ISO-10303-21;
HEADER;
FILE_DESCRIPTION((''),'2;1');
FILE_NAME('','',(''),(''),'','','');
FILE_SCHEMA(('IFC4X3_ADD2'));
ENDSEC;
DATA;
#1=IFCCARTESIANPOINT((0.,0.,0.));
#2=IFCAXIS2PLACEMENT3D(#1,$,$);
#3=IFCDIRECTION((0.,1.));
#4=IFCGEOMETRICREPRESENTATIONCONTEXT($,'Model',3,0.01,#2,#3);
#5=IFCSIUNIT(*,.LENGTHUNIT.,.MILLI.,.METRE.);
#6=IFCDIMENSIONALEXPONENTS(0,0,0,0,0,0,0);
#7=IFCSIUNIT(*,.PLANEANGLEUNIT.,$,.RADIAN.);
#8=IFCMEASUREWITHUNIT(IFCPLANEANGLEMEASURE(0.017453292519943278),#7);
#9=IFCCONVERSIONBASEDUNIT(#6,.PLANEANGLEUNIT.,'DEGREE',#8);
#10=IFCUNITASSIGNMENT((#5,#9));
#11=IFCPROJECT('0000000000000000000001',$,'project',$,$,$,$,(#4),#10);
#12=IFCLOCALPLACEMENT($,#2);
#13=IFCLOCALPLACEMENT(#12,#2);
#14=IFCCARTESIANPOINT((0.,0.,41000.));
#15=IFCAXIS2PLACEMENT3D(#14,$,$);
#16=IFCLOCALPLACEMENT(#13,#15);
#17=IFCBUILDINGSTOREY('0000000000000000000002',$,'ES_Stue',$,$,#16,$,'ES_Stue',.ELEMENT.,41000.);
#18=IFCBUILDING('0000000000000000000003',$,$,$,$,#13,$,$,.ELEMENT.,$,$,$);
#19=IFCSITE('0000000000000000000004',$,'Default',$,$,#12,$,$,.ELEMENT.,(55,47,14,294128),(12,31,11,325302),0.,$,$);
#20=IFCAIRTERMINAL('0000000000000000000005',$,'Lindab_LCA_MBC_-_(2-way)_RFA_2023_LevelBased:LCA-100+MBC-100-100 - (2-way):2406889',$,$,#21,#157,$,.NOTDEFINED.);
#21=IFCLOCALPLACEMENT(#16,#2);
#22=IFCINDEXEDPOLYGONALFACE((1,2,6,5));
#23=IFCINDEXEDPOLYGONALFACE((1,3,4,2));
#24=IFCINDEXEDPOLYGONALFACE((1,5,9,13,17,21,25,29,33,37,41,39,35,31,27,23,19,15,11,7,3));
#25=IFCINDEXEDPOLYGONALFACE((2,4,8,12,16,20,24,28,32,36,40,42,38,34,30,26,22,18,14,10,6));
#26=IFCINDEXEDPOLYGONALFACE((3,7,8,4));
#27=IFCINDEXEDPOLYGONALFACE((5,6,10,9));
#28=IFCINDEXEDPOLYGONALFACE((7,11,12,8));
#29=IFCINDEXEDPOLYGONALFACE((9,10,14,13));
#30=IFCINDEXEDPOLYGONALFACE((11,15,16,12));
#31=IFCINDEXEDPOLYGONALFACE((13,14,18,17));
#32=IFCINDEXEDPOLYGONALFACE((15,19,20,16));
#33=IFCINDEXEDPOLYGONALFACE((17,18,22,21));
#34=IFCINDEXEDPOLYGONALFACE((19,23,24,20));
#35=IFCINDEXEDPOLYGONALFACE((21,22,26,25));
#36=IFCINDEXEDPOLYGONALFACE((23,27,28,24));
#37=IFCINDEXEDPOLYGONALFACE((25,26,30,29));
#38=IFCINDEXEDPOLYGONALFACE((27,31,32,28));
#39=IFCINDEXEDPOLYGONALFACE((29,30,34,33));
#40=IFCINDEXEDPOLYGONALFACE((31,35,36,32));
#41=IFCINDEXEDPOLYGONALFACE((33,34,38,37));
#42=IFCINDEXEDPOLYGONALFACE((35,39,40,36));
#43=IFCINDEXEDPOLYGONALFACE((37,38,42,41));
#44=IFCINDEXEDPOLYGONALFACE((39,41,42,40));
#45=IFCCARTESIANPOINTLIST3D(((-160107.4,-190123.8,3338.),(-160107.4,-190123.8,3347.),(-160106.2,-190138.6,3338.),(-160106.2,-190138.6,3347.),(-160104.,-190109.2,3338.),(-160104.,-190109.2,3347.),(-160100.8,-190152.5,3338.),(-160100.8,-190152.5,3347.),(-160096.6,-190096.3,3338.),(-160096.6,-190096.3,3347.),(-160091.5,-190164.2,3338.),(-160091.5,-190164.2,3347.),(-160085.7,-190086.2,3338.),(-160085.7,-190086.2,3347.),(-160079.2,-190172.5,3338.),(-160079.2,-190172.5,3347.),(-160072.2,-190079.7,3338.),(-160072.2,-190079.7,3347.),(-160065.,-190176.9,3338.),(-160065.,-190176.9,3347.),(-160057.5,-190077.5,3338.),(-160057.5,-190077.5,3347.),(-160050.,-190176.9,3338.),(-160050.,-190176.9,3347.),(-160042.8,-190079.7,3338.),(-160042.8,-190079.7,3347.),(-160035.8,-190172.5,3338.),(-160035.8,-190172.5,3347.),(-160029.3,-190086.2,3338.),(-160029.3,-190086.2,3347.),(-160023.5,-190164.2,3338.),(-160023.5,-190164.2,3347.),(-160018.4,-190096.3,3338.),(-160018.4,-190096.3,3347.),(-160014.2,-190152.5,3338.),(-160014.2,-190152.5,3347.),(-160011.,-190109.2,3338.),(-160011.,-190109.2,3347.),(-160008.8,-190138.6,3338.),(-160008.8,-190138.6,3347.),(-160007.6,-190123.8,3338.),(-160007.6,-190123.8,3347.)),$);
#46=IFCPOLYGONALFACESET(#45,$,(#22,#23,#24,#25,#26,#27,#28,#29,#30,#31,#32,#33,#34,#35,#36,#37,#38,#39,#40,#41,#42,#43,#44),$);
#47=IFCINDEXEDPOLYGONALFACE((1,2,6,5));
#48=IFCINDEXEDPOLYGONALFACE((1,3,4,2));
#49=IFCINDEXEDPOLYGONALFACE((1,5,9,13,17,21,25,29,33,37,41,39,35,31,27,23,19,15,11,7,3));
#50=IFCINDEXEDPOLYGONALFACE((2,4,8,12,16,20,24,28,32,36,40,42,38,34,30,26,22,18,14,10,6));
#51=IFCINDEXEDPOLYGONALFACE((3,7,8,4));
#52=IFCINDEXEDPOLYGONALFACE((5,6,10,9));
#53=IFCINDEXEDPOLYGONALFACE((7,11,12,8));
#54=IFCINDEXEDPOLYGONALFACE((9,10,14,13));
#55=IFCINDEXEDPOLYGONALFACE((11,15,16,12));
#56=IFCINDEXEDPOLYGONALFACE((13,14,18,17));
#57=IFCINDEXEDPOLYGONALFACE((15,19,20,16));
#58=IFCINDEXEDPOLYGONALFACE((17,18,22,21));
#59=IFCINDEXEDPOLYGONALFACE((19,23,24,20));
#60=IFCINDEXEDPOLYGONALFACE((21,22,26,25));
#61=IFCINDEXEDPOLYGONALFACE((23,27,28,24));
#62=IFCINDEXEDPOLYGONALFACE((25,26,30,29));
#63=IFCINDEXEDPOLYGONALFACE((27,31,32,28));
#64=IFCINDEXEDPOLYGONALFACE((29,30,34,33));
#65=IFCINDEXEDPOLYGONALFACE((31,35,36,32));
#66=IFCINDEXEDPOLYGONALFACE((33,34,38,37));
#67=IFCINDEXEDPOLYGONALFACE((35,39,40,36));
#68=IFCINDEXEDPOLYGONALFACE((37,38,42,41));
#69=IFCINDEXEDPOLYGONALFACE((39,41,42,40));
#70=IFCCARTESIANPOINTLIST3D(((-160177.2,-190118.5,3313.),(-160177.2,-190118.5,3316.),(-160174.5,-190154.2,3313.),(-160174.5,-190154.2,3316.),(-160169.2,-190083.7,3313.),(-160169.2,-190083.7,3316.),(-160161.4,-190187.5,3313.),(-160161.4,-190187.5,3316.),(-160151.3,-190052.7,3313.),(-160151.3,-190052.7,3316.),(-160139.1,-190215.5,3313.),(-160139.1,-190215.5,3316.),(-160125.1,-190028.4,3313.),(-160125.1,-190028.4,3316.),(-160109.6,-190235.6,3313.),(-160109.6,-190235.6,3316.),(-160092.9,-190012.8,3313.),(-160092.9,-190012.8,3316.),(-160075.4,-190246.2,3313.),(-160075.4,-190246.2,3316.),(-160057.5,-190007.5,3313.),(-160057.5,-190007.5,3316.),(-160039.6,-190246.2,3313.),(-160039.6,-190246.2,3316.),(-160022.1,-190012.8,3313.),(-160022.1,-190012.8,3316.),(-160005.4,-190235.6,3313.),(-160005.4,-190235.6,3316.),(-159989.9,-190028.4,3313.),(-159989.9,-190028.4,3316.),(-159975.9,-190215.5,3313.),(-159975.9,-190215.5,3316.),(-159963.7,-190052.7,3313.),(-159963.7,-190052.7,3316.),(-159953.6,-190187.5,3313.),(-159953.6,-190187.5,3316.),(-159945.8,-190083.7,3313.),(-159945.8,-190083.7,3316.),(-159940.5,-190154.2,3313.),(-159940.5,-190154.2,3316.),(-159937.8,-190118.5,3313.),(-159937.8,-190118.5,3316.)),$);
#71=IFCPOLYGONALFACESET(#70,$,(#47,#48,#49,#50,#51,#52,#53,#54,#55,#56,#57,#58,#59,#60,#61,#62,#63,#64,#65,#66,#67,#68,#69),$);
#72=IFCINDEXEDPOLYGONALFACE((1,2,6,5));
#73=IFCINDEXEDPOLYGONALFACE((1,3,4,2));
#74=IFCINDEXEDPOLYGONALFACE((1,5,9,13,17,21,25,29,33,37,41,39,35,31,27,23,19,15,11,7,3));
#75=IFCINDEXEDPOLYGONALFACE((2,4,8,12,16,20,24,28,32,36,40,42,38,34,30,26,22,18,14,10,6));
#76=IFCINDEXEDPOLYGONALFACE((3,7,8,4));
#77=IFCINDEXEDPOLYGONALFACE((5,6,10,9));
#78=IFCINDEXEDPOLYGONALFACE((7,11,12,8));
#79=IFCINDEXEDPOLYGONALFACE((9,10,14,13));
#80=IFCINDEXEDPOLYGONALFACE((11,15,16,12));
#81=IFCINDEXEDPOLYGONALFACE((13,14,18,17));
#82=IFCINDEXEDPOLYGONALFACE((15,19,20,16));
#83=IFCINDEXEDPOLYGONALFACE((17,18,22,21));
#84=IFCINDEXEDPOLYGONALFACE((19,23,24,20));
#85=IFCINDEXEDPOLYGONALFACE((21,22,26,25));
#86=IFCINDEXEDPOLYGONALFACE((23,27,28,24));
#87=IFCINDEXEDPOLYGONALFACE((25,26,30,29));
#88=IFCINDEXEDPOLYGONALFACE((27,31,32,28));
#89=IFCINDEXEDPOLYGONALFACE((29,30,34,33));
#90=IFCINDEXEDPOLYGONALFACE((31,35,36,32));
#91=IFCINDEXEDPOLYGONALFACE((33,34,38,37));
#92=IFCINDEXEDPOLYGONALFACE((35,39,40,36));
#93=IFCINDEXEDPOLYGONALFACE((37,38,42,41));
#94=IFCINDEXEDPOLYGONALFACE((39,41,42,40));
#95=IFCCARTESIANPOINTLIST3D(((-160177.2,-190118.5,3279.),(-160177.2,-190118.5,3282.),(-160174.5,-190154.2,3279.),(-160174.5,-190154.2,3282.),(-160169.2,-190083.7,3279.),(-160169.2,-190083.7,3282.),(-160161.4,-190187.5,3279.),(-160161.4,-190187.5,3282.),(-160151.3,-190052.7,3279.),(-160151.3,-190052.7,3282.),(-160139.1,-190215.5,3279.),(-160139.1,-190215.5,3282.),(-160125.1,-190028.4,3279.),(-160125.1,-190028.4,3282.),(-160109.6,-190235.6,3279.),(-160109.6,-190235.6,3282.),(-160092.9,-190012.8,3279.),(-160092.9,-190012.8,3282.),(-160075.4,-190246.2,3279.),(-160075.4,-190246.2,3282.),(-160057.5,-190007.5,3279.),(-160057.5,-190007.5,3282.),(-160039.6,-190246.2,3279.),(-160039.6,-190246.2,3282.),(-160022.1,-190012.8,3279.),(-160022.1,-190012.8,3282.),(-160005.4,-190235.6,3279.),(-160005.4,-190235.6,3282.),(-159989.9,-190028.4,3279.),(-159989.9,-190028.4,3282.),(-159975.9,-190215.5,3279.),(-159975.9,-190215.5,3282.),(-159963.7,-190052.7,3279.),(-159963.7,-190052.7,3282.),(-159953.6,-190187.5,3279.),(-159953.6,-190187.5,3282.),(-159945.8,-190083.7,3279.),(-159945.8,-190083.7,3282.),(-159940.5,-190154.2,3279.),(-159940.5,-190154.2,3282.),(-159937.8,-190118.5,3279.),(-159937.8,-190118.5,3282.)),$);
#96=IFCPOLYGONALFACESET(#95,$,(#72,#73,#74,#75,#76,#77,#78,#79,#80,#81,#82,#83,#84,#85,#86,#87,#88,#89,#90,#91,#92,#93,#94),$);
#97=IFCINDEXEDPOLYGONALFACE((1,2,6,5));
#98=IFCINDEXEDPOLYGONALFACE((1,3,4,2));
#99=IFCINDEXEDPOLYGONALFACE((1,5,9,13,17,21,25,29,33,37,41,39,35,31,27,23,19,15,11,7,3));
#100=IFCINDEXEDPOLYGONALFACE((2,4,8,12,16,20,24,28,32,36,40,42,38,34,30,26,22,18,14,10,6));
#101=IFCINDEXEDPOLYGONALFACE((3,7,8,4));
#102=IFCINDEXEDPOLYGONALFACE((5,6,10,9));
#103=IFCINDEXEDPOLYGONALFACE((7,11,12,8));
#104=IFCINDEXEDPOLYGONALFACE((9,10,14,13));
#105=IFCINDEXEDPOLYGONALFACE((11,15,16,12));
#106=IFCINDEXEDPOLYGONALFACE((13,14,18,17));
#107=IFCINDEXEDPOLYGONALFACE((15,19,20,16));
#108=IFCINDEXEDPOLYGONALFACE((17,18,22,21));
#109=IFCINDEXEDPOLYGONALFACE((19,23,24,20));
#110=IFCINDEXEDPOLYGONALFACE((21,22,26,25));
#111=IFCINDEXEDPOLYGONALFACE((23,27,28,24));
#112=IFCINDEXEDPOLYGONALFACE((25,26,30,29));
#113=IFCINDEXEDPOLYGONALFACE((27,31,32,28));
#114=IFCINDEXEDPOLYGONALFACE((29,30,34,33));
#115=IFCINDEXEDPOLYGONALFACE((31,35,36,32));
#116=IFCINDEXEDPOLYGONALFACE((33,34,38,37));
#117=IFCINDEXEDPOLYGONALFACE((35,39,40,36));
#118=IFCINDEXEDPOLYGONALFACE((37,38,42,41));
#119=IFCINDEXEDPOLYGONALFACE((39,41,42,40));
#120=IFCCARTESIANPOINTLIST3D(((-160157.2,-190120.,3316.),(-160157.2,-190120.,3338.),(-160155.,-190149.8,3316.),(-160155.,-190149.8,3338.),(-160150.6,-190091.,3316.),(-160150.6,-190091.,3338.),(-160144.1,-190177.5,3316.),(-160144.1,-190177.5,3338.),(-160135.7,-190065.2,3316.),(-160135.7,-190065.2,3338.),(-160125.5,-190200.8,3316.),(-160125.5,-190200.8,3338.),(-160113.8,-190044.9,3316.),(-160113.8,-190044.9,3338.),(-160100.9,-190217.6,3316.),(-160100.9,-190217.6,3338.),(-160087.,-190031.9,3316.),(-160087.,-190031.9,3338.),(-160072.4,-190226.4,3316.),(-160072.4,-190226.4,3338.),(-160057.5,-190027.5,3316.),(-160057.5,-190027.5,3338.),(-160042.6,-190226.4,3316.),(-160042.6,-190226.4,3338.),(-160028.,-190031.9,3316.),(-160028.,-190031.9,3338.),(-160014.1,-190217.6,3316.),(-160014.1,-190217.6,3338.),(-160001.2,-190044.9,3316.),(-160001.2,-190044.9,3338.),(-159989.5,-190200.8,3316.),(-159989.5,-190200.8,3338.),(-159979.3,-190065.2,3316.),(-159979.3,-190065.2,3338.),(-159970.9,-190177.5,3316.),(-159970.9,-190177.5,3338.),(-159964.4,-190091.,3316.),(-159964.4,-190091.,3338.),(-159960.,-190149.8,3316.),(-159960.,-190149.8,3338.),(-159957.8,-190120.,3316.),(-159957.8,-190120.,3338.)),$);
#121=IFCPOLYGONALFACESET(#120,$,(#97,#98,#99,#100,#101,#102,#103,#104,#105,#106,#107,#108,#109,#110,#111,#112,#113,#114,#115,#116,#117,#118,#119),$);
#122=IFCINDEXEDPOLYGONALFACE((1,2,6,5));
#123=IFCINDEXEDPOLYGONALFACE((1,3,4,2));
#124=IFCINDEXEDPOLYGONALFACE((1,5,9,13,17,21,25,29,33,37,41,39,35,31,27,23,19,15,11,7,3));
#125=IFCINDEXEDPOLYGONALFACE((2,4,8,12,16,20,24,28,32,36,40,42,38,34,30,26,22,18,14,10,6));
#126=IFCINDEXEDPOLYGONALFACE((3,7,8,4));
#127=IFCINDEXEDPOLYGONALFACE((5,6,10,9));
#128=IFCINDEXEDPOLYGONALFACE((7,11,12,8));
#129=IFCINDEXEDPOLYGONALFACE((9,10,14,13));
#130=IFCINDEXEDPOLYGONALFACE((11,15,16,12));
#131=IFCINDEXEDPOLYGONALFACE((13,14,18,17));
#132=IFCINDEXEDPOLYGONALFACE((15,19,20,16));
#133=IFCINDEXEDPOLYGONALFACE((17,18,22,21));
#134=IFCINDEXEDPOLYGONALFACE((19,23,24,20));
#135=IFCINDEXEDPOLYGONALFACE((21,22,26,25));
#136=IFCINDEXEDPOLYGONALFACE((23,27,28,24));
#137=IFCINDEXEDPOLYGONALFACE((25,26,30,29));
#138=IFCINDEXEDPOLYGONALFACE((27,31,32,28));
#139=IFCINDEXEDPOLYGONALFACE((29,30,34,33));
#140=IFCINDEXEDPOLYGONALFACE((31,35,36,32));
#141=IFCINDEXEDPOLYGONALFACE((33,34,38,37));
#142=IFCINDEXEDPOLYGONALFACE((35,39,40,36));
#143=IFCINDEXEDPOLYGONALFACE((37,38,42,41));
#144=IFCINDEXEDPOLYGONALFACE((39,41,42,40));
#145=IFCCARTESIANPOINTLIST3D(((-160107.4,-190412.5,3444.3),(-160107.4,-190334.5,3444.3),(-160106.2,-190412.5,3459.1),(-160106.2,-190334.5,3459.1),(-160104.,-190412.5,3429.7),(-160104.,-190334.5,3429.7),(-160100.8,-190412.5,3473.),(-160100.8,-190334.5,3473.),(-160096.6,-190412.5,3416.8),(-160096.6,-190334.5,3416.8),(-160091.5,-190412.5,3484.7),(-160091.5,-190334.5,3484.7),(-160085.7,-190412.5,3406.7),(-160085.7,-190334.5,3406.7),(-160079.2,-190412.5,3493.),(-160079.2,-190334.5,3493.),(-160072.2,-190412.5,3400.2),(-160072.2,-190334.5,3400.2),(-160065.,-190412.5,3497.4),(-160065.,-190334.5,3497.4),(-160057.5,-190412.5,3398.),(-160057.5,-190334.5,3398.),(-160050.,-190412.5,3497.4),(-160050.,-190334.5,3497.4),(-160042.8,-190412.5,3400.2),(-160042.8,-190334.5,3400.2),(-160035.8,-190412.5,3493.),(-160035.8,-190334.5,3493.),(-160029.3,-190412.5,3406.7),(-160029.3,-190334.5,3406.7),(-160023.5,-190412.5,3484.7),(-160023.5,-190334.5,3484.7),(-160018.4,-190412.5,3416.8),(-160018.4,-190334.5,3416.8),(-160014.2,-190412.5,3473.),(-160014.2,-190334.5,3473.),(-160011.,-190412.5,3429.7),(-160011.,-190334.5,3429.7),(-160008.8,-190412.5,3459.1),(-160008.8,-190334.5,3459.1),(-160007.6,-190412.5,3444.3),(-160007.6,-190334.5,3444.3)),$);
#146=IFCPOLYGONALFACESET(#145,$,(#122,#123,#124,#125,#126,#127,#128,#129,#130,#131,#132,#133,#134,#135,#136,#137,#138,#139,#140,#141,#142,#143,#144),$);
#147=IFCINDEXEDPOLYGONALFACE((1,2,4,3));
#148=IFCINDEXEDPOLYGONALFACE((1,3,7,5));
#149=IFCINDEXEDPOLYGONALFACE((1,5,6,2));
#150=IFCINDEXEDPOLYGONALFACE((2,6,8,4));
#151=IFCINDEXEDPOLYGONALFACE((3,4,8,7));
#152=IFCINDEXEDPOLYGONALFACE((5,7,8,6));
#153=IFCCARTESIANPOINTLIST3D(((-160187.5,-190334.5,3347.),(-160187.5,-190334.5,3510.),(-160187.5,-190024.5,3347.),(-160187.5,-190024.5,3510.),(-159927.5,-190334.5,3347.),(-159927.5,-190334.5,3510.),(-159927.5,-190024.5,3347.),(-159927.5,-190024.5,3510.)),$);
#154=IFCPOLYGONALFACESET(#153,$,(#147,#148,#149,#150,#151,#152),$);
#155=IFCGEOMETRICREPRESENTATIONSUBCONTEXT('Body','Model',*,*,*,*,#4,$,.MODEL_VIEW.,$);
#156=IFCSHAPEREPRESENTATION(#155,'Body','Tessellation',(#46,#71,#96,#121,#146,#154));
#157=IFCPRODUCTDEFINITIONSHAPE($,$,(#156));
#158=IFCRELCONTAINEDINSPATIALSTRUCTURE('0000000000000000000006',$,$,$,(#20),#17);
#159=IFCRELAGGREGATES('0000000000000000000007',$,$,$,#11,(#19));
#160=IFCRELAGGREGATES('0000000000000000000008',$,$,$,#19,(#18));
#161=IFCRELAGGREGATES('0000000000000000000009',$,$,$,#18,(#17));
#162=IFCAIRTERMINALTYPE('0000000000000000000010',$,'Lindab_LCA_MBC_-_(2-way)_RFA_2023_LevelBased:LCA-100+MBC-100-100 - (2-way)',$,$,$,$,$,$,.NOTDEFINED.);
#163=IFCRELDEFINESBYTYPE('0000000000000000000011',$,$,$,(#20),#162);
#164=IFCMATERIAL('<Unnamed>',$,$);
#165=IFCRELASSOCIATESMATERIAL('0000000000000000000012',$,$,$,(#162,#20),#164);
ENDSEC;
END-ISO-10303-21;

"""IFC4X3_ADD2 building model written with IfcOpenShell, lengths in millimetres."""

from ifc_helpers import new_model, entity, si_unit, converted_unit, direction, frame, frame_2d, origin, origin_2d_with_axis, place, context, subcontext, project, spatial, rectangle, circle, extrude, source, transform, mapped, material, type_object, type_shapes, element, save


model = new_model("IFC4X3_ADD2")

# Units and contexts
model_context = context("Model", 3, precision=0.01, world=origin(), true_north=direction((0.0, 1.0)))
body_context = subcontext(model_context, "Body", "Model", "MODEL_VIEW")
ifc_project = project(units=[si_unit("LENGTHUNIT", "METRE", prefix="MILLI"), converted_unit("PLANEANGLEUNIT", "DEGREE", entity("IfcPlaneAngleMeasure", 0.017453292519943278), si_unit("PLANEANGLEUNIT", "RADIAN"), dimensions=[0, 0, 0, 0, 0, 0, 0])], contexts=[model_context])

# Site, building, storey
site_placement = place(None, origin())
site = spatial("IfcSite", under=ifc_project, at=site_placement, Name="Default", CompositionType="ELEMENT", RefLatitude=(55, 47, 14, 294128), RefLongitude=(12, 31, 11, 325302), RefElevation=0.0)
building_placement = place(site_placement, origin())
building = spatial("IfcBuilding", under=site, at=building_placement, CompositionType="ELEMENT")
storey_placement = place(building_placement, frame((0.0, 0.0, 41000.0)))
storey = spatial("IfcBuildingStorey", under=building, at=storey_placement, Name="ES_Stue", LongName="ES_Stue", CompositionType="ELEMENT", Elevation=41000.0)

# Air terminal
ifc_material_1 = material(Name="<Unnamed>")
air_terminal_type_1 = type_object("IfcAirTerminalType", Name="Lindab_LCA_MBC_-_(2-way)_RFA_2023_LevelBased:LCA-100+MBC-100-100 - (2-way)", PredefinedType="NOTDEFINED", material=ifc_material_1)
shared_shape_1 = source(origin(), body_context, "Body", "SweptSolid", [
    extrude(circle(Radius=50.0, at=frame_2d((0.0, 0.0), x_axis=(1.0, 0.0))), frame((0.0, 0.0, 22.0)), (0.0, 0.0, 1.0), 9.0),
    extrude(circle(Radius=120.0, at=frame_2d((0.0, 0.0), x_axis=(1.0, 0.0))), frame((0.0, 0.0, -3.0)), (0.0, 0.0, 1.0), 3.0),
    extrude(circle(Radius=120.0, at=frame_2d((0.0, 0.0), x_axis=(1.0, 0.0))), frame((0.0, 0.0, -37.0)), (0.0, 0.0, 1.0), 3.0),
    extrude(circle(Radius=100.0, at=frame_2d((0.0, 0.0), x_axis=(1.0, 0.0))), origin(), (0.0, 0.0, 1.0), 22.0),
    extrude(circle(Radius=50.0, at=frame_2d((0.0, 0.0), x_axis=(1.0, 0.0))), frame((-285.0, 0.0, 132.0), z_axis=(1.0, 0.0, 0.0), x_axis=(0.0, 0.0, -1.0)), (0.0, 0.0, 1.0), 78.0),
    extrude(rectangle(XDim=260.0, YDim=310.0, at=origin_2d_with_axis()), frame((-52.0, 0.0, 31.0), z_axis=(0.0, 0.0, 1.0), x_axis=(0.0, -1.0, 0.0)), (0.0, 0.0, 1.0), 163.0),
])
type_shapes(air_terminal_type_1, [shared_shape_1])
air_terminal_1_placement = place(storey_placement, frame((-160057.5, -190127.5, 3316.0), z_axis=(0.0, 0.0, 1.0), x_axis=(0.0, 1.0, 0.0)))
element("IfcAirTerminal", 1, at=air_terminal_1_placement, inside=storey, type_object=air_terminal_type_1, material=ifc_material_1, Name="Lindab_LCA_MBC_-_(2-way)_RFA_2023_LevelBased:LCA-100+MBC-100-100 - (2-way):2406889", PredefinedType="NOTDEFINED", context=body_context, shape_type="MappedRepresentation", body=[
    mapped(shared_shape_1, transform((0.0, 0.0, 0.0), scale=1.0)),
])

save(model, "model.ifc")
